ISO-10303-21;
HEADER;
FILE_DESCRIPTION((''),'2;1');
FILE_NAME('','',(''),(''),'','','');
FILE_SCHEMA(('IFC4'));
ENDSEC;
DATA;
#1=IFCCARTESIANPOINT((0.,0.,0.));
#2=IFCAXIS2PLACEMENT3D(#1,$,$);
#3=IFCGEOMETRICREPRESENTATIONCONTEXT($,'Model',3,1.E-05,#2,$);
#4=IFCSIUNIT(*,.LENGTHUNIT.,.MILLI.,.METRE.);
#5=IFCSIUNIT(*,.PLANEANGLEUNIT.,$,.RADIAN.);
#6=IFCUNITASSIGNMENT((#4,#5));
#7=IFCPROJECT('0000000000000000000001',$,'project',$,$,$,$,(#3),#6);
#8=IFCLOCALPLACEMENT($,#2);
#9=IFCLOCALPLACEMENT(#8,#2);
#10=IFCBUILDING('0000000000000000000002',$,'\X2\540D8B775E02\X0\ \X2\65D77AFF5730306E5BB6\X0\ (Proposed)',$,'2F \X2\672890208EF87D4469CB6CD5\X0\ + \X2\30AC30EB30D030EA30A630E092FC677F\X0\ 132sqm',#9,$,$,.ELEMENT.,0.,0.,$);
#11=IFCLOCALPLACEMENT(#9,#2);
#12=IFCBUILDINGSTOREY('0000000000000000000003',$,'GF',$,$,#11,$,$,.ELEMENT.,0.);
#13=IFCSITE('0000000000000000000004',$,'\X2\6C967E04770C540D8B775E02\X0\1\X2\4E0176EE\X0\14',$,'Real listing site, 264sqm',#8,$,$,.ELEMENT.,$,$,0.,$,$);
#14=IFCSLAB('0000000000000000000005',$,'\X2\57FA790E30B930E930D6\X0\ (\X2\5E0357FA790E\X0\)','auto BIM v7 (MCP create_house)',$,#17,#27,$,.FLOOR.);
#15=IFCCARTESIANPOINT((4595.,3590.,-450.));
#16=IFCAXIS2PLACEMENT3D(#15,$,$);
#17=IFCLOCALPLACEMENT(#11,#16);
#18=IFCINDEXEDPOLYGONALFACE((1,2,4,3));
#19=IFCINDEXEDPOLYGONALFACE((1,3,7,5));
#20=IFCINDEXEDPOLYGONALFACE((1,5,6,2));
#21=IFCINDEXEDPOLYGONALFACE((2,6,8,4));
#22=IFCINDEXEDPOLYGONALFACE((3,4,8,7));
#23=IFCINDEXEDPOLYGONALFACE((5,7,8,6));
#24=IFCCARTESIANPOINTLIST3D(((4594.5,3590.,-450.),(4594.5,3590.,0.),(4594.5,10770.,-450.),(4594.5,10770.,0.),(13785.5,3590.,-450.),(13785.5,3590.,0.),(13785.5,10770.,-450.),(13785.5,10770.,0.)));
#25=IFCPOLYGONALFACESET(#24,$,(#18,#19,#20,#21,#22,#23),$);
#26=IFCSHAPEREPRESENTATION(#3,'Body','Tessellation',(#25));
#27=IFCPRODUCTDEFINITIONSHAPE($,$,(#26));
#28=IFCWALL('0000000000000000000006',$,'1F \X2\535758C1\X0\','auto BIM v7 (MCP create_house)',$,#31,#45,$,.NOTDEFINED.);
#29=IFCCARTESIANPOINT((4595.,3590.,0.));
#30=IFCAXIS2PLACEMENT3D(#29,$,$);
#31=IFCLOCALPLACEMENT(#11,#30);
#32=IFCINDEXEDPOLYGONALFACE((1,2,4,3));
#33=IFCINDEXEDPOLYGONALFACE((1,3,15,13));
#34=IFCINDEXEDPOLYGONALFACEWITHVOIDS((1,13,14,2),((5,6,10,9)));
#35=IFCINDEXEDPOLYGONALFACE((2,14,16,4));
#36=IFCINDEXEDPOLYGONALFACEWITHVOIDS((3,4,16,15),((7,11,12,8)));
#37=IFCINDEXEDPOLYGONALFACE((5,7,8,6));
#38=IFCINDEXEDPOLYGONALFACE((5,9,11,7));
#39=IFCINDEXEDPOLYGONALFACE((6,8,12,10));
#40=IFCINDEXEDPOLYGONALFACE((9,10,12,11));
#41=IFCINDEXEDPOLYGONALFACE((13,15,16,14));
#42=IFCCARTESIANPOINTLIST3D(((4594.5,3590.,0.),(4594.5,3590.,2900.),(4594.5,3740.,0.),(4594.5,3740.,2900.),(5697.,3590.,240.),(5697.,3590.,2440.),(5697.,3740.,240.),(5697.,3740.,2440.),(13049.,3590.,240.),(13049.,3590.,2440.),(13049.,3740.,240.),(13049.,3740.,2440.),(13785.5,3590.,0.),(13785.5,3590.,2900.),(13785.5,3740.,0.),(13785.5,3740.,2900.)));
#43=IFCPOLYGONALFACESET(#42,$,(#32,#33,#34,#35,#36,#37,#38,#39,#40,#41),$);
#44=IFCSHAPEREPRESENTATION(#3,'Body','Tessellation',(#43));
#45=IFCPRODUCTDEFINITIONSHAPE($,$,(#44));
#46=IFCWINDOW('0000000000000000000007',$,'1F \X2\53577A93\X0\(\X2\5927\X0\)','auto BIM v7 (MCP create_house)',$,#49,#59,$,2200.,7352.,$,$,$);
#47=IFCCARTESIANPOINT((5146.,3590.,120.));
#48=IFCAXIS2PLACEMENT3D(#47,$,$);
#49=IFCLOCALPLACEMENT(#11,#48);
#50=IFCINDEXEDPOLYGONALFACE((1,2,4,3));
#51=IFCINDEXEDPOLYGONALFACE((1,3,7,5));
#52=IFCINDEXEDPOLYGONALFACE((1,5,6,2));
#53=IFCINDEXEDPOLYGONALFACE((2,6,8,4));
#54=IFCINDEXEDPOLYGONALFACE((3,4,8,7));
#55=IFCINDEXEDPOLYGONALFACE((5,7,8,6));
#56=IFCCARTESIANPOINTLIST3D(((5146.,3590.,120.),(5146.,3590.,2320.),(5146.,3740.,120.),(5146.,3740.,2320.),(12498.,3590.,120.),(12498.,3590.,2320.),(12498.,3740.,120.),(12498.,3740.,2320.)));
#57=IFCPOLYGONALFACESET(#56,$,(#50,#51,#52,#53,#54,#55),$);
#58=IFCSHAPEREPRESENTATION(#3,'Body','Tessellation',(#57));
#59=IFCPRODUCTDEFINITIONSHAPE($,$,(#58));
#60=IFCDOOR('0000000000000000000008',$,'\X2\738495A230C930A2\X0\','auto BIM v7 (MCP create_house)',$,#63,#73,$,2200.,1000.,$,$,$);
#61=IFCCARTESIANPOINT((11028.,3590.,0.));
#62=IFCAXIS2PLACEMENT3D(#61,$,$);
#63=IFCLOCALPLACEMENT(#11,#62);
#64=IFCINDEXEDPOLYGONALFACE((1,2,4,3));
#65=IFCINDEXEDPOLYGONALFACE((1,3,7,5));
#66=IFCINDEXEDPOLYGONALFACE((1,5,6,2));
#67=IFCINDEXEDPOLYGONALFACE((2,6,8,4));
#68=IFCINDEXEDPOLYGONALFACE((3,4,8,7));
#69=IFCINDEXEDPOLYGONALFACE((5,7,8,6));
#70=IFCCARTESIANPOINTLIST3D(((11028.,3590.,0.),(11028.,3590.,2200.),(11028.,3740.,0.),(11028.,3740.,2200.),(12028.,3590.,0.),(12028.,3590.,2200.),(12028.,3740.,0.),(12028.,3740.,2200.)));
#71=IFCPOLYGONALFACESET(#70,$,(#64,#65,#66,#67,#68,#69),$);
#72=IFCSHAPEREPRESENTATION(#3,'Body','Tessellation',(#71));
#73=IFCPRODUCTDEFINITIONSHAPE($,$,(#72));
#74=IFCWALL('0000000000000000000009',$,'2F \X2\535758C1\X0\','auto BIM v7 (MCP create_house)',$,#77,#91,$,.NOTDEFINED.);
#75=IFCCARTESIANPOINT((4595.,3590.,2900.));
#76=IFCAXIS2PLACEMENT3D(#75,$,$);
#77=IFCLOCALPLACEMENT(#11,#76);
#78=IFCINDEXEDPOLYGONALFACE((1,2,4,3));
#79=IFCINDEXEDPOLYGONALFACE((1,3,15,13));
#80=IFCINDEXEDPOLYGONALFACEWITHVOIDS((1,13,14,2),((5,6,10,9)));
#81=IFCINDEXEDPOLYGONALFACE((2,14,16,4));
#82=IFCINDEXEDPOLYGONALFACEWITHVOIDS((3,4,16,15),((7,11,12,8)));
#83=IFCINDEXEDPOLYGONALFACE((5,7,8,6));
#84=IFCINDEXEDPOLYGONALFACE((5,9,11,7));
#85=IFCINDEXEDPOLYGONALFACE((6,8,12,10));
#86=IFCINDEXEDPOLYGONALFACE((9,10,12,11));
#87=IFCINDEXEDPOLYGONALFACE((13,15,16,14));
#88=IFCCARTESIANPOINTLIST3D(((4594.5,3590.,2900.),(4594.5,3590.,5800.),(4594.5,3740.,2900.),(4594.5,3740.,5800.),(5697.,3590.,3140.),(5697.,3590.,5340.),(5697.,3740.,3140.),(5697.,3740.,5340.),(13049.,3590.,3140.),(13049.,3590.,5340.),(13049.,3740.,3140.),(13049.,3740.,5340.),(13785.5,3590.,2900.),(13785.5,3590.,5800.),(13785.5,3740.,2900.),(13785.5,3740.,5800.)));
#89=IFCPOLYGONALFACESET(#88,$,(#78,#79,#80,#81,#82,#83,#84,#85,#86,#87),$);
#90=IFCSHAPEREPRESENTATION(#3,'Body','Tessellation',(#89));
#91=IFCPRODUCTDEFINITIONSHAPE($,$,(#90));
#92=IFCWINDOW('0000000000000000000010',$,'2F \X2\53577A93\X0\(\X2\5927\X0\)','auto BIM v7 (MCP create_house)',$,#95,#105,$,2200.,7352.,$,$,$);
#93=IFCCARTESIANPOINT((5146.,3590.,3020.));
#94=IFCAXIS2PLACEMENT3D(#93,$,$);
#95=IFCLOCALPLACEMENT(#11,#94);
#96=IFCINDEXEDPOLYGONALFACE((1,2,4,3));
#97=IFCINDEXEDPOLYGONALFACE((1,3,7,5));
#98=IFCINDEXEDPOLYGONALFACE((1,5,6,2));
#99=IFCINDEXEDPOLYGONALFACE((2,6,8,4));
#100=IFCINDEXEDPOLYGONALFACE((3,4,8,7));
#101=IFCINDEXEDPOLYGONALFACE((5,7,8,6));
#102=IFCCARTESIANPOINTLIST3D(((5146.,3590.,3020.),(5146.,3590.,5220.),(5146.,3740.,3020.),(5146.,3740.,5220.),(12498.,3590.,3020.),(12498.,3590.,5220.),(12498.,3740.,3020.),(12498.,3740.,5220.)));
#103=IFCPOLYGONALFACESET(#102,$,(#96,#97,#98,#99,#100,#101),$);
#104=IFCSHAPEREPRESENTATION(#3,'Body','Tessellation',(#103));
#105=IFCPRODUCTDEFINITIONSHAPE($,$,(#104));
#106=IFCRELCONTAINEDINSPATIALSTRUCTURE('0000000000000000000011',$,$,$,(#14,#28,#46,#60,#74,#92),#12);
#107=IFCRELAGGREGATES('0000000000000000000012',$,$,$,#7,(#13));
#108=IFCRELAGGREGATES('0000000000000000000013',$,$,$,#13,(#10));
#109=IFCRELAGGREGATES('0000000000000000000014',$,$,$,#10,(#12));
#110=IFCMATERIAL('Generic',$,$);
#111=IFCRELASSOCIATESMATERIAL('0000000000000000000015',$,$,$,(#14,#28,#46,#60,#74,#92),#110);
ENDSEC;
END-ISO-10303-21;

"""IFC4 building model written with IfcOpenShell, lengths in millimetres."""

from ifc_helpers import new_model, si_unit, frame, frame_2d, origin, place, context, project, spatial, rectangle, extrude, material, element, fill, save


model = new_model("IFC4")

# Units and contexts
model_context = context("Model", 3, precision=1e-05, world=origin())
ifc_project = project(units=[si_unit("LENGTHUNIT", "METRE", prefix="MILLI"), si_unit("PLANEANGLEUNIT", "RADIAN")], contexts=[model_context])

# Site, building, storey
site_placement = place(None, origin())
site = spatial("IfcSite", under=ifc_project, at=site_placement, Name="沖縄県名護市1丁目14", ObjectType="Real listing site, 264sqm", CompositionType="ELEMENT", RefElevation=0.0)
building_placement = place(site_placement, origin())
building = spatial("IfcBuilding", under=site, at=building_placement, Name="名護市 旗竿地の家 (Proposed)", ObjectType="2F 木造軸組構法 + ガルバリウム鋼板 132sqm", CompositionType="ELEMENT", ElevationOfRefHeight=0.0, ElevationOfTerrain=0.0)
storey_placement = place(building_placement, origin())
storey = spatial("IfcBuildingStorey", under=building, at=storey_placement, Name="GF", CompositionType="ELEMENT", Elevation=0.0)

# Slab
ifc_material = material(Name="Generic")
slab_1_placement = place(storey_placement, frame((4595.0, 3590.0, -450.0)))
element("IfcSlab", 1, at=slab_1_placement, inside=storey, material=ifc_material, Name="基礎スラブ (布基礎)", Description="auto BIM v7 (MCP create_house)", PredefinedType="FLOOR", context=model_context, shape_type="SweptSolid", body=[
    extrude(rectangle(XDim=9191.0, YDim=7180.0, at=frame_2d((4595.0, 3590.0))), frame((4595.0, 3590.0, -450.0)), (0.0, 0.0, 1.0), 450.0),
])

# Wall, openings, window, door
wall_1_placement = place(storey_placement, frame((4595.0, 3590.0, 0.0)))
wall_1 = element("IfcWall", 2, at=wall_1_placement, inside=storey, material=ifc_material, Name="1F 南壁", Description="auto BIM v7 (MCP create_house)", PredefinedType="NOTDEFINED", context=model_context, shape_type="SweptSolid", body=[
    extrude(rectangle(XDim=9191.0, YDim=150.0, at=frame_2d((4595.0, 75.0))), frame((4595.0, 3590.0, 0.0)), (0.0, 0.0, 1.0), 2900.0),
])
opening_1_placement = place(storey_placement, frame((5146.0, 3590.0, 120.0)))
opening_1 = element("IfcOpeningElement", 3, at=opening_1_placement, cuts=wall_1, PredefinedType="NOTDEFINED", context=model_context, shape_type="SweptSolid", body=[
    extrude(rectangle(XDim=7352.0, YDim=150.0, at=frame_2d((3676.0, 75.0))), frame((5146.0, 3590.0, 120.0)), (0.0, 0.0, 1.0), 2200.0),
])
opening_2_placement = place(storey_placement, frame((11028.0, 3590.0, 0.0)))
opening_2 = element("IfcOpeningElement", 4, at=opening_2_placement, cuts=wall_1, PredefinedType="NOTDEFINED", context=model_context, shape_type="SweptSolid", body=[
    extrude(rectangle(XDim=1000.0, YDim=150.0, at=frame_2d((500.0, 75.0))), frame((11028.0, 3590.0, 0.0)), (0.0, 0.0, 1.0), 2200.0),
])
window_1_placement = place(storey_placement, frame((5146.0, 3590.0, 120.0)))
window_1 = element("IfcWindow", 5, at=window_1_placement, inside=storey, material=ifc_material, Name="1F 南窓(大)", Description="auto BIM v7 (MCP create_house)", OverallHeight=2200.0, OverallWidth=7352.0, context=model_context, shape_type="SweptSolid", body=[
    extrude(rectangle(XDim=7352.0, YDim=150.0, at=frame_2d((3676.0, 75.0))), frame((5146.0, 3590.0, 120.0)), (0.0, 0.0, 1.0), 2200.0),
])
fill(opening_1, window_1)
door_placement = place(storey_placement, frame((11028.0, 3590.0, 0.0)))
door = element("IfcDoor", 6, at=door_placement, inside=storey, material=ifc_material, Name="玄関ドア", Description="auto BIM v7 (MCP create_house)", OverallHeight=2200.0, OverallWidth=1000.0, context=model_context, shape_type="SweptSolid", body=[
    extrude(rectangle(XDim=1000.0, YDim=150.0, at=frame_2d((500.0, 75.0))), frame((11028.0, 3590.0, 0.0)), (0.0, 0.0, 1.0), 2200.0),
])
fill(opening_2, door)

# Wall, opening, window
wall_2_placement = place(storey_placement, frame((4595.0, 3590.0, 2900.0)))
wall_2 = element("IfcWall", 7, at=wall_2_placement, inside=storey, material=ifc_material, Name="2F 南壁", Description="auto BIM v7 (MCP create_house)", PredefinedType="NOTDEFINED", context=model_context, shape_type="SweptSolid", body=[
    extrude(rectangle(XDim=9191.0, YDim=150.0, at=frame_2d((4595.0, 75.0))), frame((4595.0, 3590.0, 2900.0)), (0.0, 0.0, 1.0), 2900.0),
])
opening_3_placement = place(storey_placement, frame((5146.0, 3590.0, 3020.0)))
opening_3 = element("IfcOpeningElement", 8, at=opening_3_placement, cuts=wall_2, PredefinedType="NOTDEFINED", context=model_context, shape_type="SweptSolid", body=[
    extrude(rectangle(XDim=7352.0, YDim=150.0, at=frame_2d((3676.0, 75.0))), frame((5146.0, 3590.0, 3020.0)), (0.0, 0.0, 1.0), 2200.0),
])
window_2_placement = place(storey_placement, frame((5146.0, 3590.0, 3020.0)))
window_2 = element("IfcWindow", 9, at=window_2_placement, inside=storey, material=ifc_material, Name="2F 南窓(大)", Description="auto BIM v7 (MCP create_house)", OverallHeight=2200.0, OverallWidth=7352.0, context=model_context, shape_type="SweptSolid", body=[
    extrude(rectangle(XDim=7352.0, YDim=150.0, at=frame_2d((3676.0, 75.0))), frame((5146.0, 3590.0, 3020.0)), (0.0, 0.0, 1.0), 2200.0),
])
fill(opening_3, window_2)

save(model, "model.ifc")
